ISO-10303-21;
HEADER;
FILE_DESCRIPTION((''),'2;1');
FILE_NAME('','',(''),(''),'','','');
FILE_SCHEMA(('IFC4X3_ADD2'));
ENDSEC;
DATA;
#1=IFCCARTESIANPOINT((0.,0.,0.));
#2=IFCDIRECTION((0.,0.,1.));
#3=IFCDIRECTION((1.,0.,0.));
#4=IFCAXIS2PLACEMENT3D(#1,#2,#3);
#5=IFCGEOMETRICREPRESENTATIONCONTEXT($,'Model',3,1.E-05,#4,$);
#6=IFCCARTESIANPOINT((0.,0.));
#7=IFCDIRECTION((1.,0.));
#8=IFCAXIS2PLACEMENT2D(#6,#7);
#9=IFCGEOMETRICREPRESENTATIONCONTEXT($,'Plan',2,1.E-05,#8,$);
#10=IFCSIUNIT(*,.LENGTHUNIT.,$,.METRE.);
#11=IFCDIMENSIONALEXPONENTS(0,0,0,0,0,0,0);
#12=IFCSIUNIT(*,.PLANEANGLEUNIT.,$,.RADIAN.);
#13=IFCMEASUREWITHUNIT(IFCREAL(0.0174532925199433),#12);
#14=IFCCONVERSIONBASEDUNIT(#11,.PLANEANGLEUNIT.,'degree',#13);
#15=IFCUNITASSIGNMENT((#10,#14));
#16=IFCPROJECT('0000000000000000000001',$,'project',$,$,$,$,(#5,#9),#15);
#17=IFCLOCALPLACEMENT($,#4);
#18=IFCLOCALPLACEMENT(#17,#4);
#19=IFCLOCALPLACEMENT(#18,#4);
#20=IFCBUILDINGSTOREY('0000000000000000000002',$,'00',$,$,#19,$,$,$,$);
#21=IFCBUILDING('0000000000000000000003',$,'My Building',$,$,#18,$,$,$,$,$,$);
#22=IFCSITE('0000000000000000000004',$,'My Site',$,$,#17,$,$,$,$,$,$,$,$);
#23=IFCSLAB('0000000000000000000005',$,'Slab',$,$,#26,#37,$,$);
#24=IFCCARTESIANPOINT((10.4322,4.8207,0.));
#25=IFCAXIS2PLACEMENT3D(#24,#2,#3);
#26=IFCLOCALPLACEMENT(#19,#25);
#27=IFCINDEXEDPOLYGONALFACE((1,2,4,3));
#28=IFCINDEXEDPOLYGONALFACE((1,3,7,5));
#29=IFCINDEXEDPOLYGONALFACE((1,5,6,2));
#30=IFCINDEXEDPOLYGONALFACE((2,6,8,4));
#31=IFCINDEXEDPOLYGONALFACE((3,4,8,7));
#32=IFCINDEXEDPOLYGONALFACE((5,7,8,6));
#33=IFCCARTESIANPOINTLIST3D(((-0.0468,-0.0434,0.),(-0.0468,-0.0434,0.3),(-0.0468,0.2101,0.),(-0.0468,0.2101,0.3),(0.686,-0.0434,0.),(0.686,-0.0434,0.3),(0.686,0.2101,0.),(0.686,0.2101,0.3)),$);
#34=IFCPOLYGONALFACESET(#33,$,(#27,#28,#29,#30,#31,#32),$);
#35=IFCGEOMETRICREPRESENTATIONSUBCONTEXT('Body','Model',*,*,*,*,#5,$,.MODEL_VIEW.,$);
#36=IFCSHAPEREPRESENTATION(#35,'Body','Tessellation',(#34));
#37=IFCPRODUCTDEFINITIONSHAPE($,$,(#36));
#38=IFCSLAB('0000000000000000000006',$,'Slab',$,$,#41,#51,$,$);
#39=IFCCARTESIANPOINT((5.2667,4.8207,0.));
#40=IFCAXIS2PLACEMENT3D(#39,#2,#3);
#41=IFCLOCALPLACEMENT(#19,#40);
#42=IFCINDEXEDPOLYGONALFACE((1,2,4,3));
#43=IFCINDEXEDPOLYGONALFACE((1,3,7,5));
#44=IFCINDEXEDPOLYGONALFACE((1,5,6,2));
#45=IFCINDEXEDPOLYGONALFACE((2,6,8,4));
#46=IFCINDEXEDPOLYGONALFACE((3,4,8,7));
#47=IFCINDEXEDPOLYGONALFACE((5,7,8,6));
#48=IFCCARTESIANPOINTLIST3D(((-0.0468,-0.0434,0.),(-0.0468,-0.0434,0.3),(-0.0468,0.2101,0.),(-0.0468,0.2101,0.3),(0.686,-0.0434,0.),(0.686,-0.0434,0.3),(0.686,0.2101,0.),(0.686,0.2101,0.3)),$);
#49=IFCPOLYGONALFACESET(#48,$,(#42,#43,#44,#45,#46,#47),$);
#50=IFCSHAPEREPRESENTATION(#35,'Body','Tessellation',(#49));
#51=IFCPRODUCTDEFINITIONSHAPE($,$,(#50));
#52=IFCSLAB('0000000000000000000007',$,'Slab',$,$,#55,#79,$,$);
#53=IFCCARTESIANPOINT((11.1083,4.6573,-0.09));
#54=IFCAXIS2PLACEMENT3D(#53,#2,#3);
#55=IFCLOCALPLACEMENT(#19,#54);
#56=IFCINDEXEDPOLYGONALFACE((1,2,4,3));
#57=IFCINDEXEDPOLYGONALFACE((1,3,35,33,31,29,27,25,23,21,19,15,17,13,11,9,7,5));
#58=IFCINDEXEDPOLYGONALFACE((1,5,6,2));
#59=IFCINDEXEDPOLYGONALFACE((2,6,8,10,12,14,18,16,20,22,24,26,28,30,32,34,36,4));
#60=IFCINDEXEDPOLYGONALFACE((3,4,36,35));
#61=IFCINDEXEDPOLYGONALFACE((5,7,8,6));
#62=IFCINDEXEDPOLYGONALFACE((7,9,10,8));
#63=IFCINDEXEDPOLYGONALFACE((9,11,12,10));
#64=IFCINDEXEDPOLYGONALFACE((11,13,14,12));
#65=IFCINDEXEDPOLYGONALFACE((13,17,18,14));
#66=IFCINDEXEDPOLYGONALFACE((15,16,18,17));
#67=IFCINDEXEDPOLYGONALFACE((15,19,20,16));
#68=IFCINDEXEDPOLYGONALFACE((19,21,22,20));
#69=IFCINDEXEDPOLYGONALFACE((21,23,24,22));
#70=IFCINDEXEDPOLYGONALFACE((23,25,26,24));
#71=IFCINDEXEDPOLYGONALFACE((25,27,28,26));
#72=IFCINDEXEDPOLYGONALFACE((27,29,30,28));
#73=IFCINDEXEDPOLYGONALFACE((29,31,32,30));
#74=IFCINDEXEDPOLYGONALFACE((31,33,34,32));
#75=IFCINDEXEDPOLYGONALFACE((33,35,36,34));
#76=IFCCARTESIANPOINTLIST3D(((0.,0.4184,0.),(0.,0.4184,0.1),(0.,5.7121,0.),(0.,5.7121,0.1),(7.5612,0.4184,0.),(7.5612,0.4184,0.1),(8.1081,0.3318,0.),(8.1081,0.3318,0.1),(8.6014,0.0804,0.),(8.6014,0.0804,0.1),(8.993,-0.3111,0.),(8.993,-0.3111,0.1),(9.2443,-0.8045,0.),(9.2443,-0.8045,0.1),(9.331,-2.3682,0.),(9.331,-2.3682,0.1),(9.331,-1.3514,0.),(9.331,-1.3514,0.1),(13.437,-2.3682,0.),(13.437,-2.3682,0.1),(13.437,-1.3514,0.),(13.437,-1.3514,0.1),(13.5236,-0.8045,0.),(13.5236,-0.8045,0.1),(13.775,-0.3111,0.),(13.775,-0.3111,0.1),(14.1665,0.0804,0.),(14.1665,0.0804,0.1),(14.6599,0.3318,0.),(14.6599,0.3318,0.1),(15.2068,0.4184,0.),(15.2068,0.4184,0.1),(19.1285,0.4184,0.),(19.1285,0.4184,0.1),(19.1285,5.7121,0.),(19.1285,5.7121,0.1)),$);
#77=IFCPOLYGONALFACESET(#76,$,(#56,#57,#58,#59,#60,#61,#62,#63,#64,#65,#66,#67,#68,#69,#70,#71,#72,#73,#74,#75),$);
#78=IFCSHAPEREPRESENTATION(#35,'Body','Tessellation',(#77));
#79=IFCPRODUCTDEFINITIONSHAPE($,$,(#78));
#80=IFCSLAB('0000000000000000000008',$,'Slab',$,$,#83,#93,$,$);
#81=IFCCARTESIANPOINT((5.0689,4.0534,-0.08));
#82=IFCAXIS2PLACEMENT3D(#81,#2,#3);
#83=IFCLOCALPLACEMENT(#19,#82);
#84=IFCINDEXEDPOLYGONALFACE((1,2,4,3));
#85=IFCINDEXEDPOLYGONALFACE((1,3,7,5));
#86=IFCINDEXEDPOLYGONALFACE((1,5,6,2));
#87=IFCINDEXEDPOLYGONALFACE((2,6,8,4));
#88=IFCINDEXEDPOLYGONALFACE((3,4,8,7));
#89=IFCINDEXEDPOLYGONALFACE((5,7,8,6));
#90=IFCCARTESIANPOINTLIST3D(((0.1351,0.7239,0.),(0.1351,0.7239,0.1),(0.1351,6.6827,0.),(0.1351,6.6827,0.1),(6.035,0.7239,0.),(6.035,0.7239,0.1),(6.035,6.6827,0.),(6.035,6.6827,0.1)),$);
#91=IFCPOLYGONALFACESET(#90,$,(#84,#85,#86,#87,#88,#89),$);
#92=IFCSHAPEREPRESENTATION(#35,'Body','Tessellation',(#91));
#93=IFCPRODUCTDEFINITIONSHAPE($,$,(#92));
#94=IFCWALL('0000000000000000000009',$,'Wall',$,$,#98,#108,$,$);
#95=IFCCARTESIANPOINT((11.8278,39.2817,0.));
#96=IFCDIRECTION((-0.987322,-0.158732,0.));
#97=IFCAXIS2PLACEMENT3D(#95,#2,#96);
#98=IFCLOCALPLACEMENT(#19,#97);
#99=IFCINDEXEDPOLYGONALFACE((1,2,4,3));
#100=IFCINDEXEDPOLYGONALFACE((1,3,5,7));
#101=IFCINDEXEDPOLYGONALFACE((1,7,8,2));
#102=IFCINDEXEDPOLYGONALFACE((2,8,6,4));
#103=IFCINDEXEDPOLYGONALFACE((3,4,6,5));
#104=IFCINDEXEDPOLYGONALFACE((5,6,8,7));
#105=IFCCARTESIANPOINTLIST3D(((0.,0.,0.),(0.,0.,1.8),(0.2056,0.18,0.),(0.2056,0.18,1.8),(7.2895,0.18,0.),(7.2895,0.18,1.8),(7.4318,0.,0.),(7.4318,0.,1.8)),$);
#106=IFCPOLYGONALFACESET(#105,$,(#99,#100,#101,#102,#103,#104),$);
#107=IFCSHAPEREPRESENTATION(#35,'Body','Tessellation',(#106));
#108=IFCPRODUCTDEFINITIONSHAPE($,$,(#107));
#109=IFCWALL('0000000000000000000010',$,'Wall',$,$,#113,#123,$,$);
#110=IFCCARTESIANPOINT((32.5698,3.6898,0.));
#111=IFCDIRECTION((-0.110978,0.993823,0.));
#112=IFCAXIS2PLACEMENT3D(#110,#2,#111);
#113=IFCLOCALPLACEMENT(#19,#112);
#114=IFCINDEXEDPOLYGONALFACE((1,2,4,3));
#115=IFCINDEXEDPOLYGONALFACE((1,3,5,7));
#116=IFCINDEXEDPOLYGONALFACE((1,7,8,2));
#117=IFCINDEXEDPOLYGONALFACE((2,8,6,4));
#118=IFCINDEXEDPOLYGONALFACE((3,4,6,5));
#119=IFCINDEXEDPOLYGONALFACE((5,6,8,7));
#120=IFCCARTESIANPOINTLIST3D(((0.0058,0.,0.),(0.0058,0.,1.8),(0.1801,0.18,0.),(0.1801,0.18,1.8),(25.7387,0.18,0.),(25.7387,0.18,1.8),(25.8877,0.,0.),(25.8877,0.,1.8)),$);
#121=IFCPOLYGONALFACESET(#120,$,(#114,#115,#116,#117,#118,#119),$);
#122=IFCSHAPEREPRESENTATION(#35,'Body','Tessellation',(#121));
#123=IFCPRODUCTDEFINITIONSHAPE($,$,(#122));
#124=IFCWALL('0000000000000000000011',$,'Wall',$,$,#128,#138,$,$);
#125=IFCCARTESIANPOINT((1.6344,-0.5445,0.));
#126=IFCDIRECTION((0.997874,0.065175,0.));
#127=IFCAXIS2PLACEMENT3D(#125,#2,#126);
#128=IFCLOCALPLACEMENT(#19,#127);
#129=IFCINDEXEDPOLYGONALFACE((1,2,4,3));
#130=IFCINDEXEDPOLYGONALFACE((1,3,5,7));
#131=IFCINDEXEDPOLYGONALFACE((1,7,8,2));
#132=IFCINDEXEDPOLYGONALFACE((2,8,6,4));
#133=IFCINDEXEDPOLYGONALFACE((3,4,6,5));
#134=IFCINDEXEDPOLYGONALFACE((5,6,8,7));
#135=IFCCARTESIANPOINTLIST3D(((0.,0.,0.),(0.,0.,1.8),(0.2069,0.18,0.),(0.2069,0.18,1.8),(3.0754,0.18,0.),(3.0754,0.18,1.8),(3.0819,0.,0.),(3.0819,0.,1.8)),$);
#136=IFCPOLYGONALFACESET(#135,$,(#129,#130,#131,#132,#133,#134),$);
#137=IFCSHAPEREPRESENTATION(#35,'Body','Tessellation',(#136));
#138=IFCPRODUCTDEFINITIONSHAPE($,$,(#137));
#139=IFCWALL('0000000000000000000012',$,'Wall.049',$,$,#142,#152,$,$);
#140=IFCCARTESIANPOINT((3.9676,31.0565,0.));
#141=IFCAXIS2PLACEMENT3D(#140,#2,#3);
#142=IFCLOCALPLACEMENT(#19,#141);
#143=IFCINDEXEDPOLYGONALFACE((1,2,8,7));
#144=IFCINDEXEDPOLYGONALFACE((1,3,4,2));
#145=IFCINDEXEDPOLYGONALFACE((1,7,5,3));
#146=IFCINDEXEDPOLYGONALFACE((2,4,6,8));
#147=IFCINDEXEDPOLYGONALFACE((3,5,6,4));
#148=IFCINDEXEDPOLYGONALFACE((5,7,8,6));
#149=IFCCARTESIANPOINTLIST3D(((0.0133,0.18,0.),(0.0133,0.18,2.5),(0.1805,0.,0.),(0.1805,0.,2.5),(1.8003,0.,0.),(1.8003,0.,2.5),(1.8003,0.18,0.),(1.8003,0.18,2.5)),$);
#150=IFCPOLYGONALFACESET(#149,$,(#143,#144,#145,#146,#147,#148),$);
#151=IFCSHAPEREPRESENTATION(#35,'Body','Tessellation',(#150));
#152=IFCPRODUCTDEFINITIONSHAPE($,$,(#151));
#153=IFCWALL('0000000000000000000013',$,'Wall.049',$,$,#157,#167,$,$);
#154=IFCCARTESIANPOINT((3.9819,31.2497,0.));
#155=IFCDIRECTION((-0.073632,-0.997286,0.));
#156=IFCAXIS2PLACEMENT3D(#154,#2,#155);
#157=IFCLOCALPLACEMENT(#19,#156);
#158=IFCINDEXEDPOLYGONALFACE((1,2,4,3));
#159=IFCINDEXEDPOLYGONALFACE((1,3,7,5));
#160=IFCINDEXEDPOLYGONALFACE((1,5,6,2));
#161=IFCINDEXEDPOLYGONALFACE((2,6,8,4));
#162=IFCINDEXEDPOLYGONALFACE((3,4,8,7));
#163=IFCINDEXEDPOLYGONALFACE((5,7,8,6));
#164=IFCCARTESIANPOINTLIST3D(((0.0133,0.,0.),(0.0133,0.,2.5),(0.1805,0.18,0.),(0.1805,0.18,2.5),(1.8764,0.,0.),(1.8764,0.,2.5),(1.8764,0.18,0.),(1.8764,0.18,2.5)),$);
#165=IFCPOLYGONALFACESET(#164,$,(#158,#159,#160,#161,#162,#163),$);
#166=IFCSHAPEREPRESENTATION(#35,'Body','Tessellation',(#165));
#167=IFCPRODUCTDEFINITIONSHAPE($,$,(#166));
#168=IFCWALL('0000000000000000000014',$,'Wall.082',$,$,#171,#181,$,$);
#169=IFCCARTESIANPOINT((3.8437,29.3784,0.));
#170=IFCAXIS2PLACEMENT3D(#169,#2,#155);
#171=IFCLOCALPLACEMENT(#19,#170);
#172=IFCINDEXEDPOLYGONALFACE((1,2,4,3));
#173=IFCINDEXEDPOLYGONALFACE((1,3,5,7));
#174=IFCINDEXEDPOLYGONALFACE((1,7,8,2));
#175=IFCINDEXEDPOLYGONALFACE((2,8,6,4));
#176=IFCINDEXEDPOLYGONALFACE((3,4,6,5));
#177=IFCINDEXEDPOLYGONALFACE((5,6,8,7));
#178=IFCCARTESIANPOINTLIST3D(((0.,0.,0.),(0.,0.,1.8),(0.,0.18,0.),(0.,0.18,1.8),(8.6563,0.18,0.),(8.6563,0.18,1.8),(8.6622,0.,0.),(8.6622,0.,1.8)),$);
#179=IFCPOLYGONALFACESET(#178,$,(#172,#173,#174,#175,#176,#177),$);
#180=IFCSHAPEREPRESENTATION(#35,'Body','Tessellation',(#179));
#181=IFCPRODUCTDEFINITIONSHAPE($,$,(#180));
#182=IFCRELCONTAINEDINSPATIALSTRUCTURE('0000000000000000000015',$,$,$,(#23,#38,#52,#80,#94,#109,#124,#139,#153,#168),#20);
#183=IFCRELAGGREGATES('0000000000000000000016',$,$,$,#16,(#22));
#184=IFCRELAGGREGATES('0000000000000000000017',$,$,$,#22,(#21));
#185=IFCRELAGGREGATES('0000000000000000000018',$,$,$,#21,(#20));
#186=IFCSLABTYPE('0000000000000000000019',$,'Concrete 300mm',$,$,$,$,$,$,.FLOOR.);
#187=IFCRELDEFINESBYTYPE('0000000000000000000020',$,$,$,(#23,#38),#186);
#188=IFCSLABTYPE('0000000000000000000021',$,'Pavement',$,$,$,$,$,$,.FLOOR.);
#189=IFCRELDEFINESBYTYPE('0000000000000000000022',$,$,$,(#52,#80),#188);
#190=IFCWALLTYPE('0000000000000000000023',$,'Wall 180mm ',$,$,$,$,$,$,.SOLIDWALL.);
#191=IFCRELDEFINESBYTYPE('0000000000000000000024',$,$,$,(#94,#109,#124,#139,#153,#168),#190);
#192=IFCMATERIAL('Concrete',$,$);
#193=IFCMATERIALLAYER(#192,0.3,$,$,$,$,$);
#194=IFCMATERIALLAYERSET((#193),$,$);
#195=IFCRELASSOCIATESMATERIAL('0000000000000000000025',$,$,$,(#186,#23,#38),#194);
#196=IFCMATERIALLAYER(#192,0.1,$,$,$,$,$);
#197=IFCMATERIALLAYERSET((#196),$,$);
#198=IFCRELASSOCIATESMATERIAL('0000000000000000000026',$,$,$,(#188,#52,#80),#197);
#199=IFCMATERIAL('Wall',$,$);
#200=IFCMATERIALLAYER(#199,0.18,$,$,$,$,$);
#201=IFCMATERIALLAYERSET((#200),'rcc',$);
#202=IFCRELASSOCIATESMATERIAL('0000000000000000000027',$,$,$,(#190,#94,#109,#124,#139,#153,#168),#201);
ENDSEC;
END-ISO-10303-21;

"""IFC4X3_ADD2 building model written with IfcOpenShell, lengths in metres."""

from ifc_helpers import new_model, entity, si_unit, converted_unit, frame, origin_with_axes, origin_2d_with_axis, place, context, subcontext, project, spatial, line, indexed_curve, outline, extrude, clip, halfspace, material, layer, layer_set, layer_usage, type_object, element, save


model = new_model("IFC4X3_ADD2")

# Units and contexts
model_context = context("Model", 3, precision=1e-05, world=origin_with_axes())
plan_context = context("Plan", 2, precision=1e-05, world=origin_2d_with_axis())
body_context_1 = subcontext(model_context, "Body", "Model", "MODEL_VIEW")
ifc_project = project(units=[si_unit("LENGTHUNIT", "METRE"), converted_unit("PLANEANGLEUNIT", "degree", entity("IfcReal", 0.0174532925199433), si_unit("PLANEANGLEUNIT", "RADIAN"), dimensions=[0, 0, 0, 0, 0, 0, 0])], contexts=[model_context, plan_context])

# Site, building, storey
site_placement = place(None, origin_with_axes())
site = spatial("IfcSite", under=ifc_project, at=site_placement, Name="My Site")
building_placement = place(site_placement, origin_with_axes())
building = spatial("IfcBuilding", under=site, at=building_placement, Name="My Building")
storey_placement = place(building_placement, origin_with_axes())
storey = spatial("IfcBuildingStorey", under=building, at=storey_placement, Name="00")

# Slabs
ifc_material_1 = material(Name="Concrete")
ifc_layer_1 = layer(ifc_material_1, 0.3)
ifc_layer_set_1 = layer_set([ifc_layer_1])
ifc_layer_usage_1 = layer_usage(ifc_layer_set_1, "AXIS3", "POSITIVE", 0.0)
slab_type_1 = type_object("IfcSlabType", Name="Concrete 300mm", PredefinedType="FLOOR", material=ifc_layer_set_1)
slab_1_placement = place(storey_placement, frame((10.4322, 4.8207, 0.0), z_axis=(0.0, 0.0, 1.0), x_axis=(1.0, 0.0, 0.0)))
element("IfcSlab", 1, at=slab_1_placement, inside=storey, type_object=slab_type_1, material=ifc_layer_usage_1, Name="Slab", context=body_context_1, shape_type="SweptSolid", body=[
    extrude(outline(indexed_curve([(-0.0468, -0.0434), (0.686, -0.0434), (0.686, 0.2101), (-0.0468, 0.2101)], segments=[line(4, 1), line(1, 2), line(2, 3), line(3, 4)], self_intersect=False)), None, (0.0, 0.0, 1.0), 0.3),
])
ifc_layer_usage_2 = layer_usage(ifc_layer_set_1, "AXIS3", "POSITIVE", 0.0)
slab_2_placement = place(storey_placement, frame((5.2667, 4.8207, 0.0), z_axis=(0.0, 0.0, 1.0), x_axis=(1.0, 0.0, 0.0)))
element("IfcSlab", 2, at=slab_2_placement, inside=storey, type_object=slab_type_1, material=ifc_layer_usage_2, Name="Slab", context=body_context_1, shape_type="SweptSolid", body=[
    extrude(outline(indexed_curve([(-0.0468, 0.2101), (-0.0468, -0.0434), (0.686, -0.0434), (0.686, 0.2101)], segments=[line(4, 1), line(1, 2), line(2, 3), line(3, 4)], self_intersect=False)), None, (0.0, 0.0, 1.0), 0.3),
])
ifc_layer_2 = layer(ifc_material_1, 0.1)
ifc_layer_set_2 = layer_set([ifc_layer_2])
ifc_layer_usage_3 = layer_usage(ifc_layer_set_2, "AXIS3", "POSITIVE", 0.0)
slab_type_2 = type_object("IfcSlabType", Name="Pavement", PredefinedType="FLOOR", material=ifc_layer_set_2)
slab_3_placement = place(storey_placement, frame((11.1083, 4.6573, -0.09), z_axis=(0.0, 0.0, 1.0), x_axis=(1.0, 0.0, 0.0)))
element("IfcSlab", 3, at=slab_3_placement, inside=storey, type_object=slab_type_2, material=ifc_layer_usage_3, Name="Slab", context=body_context_1, shape_type="SweptSolid", body=[
    extrude(outline(indexed_curve([(8.1081, 0.3318), (7.5612, 0.4184), (0.0, 0.4184), (0.0, 5.7121), (19.1285, 5.7121), (19.1285, 0.4184), (15.2068, 0.4184), (14.6599, 0.3318), (14.1665, 0.0804), (13.775, -0.3111), (13.5236, -0.8045), (13.437, -1.3514), (13.437, -2.3682), (9.331, -2.3682), (9.331, -1.3514), (9.2443, -0.8045), (8.993, -0.3111), (8.6014, 0.0804)], segments=[line(3, 2), line(2, 1), line(1, 18), line(18, 17), line(17, 16), line(16, 15), line(15, 14), line(14, 13), line(13, 12), line(12, 11), line(11, 10), line(10, 9), line(9, 8), line(8, 7), line(7, 6), line(6, 5), line(5, 4), line(4, 3)], self_intersect=False)), None, (0.0, 0.0, 1.0), 0.1),
])
ifc_layer_usage_4 = layer_usage(ifc_layer_set_2, "AXIS3", "POSITIVE", 0.0)
slab_4_placement = place(storey_placement, frame((5.0689, 4.0534, -0.08), z_axis=(0.0, 0.0, 1.0), x_axis=(1.0, 0.0, 0.0)))
element("IfcSlab", 4, at=slab_4_placement, inside=storey, type_object=slab_type_2, material=ifc_layer_usage_4, Name="Slab", context=body_context_1, shape_type="SweptSolid", body=[
    extrude(outline(indexed_curve([(6.035, 0.7239), (0.1351, 0.7239), (0.1351, 6.6827), (6.035, 6.6827)], segments=[line(4, 1), line(1, 2), line(2, 3), line(3, 4)], self_intersect=False)), None, (0.0, 0.0, 1.0), 0.1),
])

# Walls
ifc_material_2 = material(Name="Wall")
ifc_layer_3 = layer(ifc_material_2, 0.18)
ifc_layer_set_3 = layer_set([ifc_layer_3], Name="rcc")
wall_type_1 = type_object("IfcWallType", Name="Wall 180mm ", PredefinedType="SOLIDWALL", material=ifc_layer_set_3)
ifc_layer_usage_5 = layer_usage(ifc_layer_set_3, "AXIS2", "POSITIVE", 0.0)
wall_1_placement = place(storey_placement, frame((11.8278, 39.2817, 0.0), z_axis=(0.0, 0.0, 1.0), x_axis=(-0.987322, -0.158732, 0.0)))
element("IfcWall", 5, at=wall_1_placement, inside=storey, type_object=wall_type_1, material=ifc_layer_usage_5, Name="Wall", context=body_context_1, shape_type="Clipping", body=[
    clip(clip(extrude(outline(indexed_curve([(0.0, 0.0), (0.0, 0.18), (7.4745, 0.18), (7.4745, 0.0), (0.0, 0.0)], self_intersect=False)), origin_with_axes(), (0.0, 0.0, 1.0), 1.8), halfspace(frame((7.4318, 0.0, 0.0), z_axis=(0.784559, 0.620055, 0.0), x_axis=(0.620055, -0.784558, 0.0)), False)), halfspace(frame((0.0, 0.0, 0.0), z_axis=(-0.658655, 0.752445, 0.0), x_axis=(0.752445, 0.658655, 0.0)), False)),
])
ifc_layer_usage_6 = layer_usage(ifc_layer_set_3, "AXIS2", "POSITIVE", 0.0)
wall_2_placement = place(storey_placement, frame((32.5698, 3.6898, 0.0), z_axis=(0.0, 0.0, 1.0), x_axis=(-0.110978, 0.993823, 0.0)))
element("IfcWall", 6, at=wall_2_placement, inside=storey, type_object=wall_type_1, material=ifc_layer_usage_6, Name="Wall", context=body_context_1, shape_type="Clipping", body=[
    clip(clip(extrude(outline(indexed_curve([(0.0, 0.0), (0.0, 0.18), (25.9219, 0.18), (25.9219, 0.0), (0.0, 0.0)], self_intersect=False)), origin_with_axes(), (0.0, 0.0, 1.0), 1.8), halfspace(frame((0.0058, 0.0, 0.0), z_axis=(-0.718417, 0.695612, 0.0), x_axis=(0.695612, 0.718418, 0.0)), False)), halfspace(frame((25.8877, 0.0, 0.0), z_axis=(0.770377, 0.637589, 0.0), x_axis=(0.637589, -0.770377, 0.0)), False)),
])
ifc_layer_usage_7 = layer_usage(ifc_layer_set_3, "AXIS2", "POSITIVE", 0.0)
wall_3_placement = place(storey_placement, frame((1.6344, -0.5445, 0.0), z_axis=(0.0, 0.0, 1.0), x_axis=(0.997874, 0.065175, 0.0)))
element("IfcWall", 7, at=wall_3_placement, inside=storey, type_object=wall_type_1, material=ifc_layer_usage_7, Name="Wall", context=body_context_1, shape_type="Clipping", body=[
    clip(clip(extrude(outline(indexed_curve([(0.0, 0.0), (0.0, 0.18), (5.5676, 0.18), (5.5676, 0.0), (0.0, 0.0)], self_intersect=False)), origin_with_axes(), (0.0, 0.0, 1.0), 1.8), halfspace(frame((3.0819, 0.0, 0.0), z_axis=(0.999347, 0.036143, 0.0), x_axis=(0.036143, -0.999347, 0.0)), False)), halfspace(frame((0.0, 0.0, 0.0), z_axis=(-0.656326, 0.754478, 0.0), x_axis=(0.754478, 0.656326, 0.0)), False)),
])
ifc_layer_usage_8 = layer_usage(ifc_layer_set_3, "AXIS2", "POSITIVE", 0.0)
wall_4_placement = place(storey_placement, frame((3.9676, 31.0565, 0.0), z_axis=(0.0, 0.0, 1.0), x_axis=(1.0, 0.0, 0.0)))
element("IfcWall", 8, at=wall_4_placement, inside=storey, type_object=wall_type_1, material=ifc_layer_usage_8, Name="Wall.049", context=body_context_1, shape_type="Clipping", body=[
    clip(extrude(outline(indexed_curve([(0.0, 0.0), (0.0, 0.18), (1.8003, 0.18), (1.8003, 0.0), (0.0, 0.0)], self_intersect=False)), origin_with_axes(), (0.0, 0.0, 1.0), 2.5), halfspace(frame((0.1805, 0.0, 0.0), z_axis=(-0.732678, -0.680576, 0.0), x_axis=(-0.680576, 0.732678, 0.0)), False)),
])

# Wall
ifc_layer_usage_9 = layer_usage(ifc_layer_set_3, "AXIS2", "POSITIVE", 0.0)
wall_5_placement = place(storey_placement, frame((3.9819, 31.2497, 0.0), z_axis=(0.0, 0.0, 1.0), x_axis=(-0.073632, -0.997286, 0.0)))
element("IfcWall", 9, at=wall_5_placement, inside=storey, type_object=wall_type_1, material=ifc_layer_usage_9, Name="Wall.049", context=body_context_1, shape_type="Clipping", body=[
    clip(extrude(outline(indexed_curve([(0.0, 0.0), (0.0, 0.18), (1.8764, 0.18), (1.8764, 0.0), (0.0, 0.0)], self_intersect=False)), origin_with_axes(), (0.0, 0.0, 1.0), 2.5), halfspace(frame((0.0133, 0.0, 0.0), z_axis=(-0.732676, 0.680577, 0.0), x_axis=(0.680577, 0.732676, 0.0)), False)),
])

# Wall
ifc_layer_usage_10 = layer_usage(ifc_layer_set_3, "AXIS2", "POSITIVE", 0.0)
wall_6_placement = place(storey_placement, frame((3.8437, 29.3784, 0.0), z_axis=(0.0, 0.0, 1.0), x_axis=(-0.073632, -0.997286, 0.0)))
element("IfcWall", 10, at=wall_6_placement, inside=storey, type_object=wall_type_1, material=ifc_layer_usage_10, Name="Wall.082", context=body_context_1, shape_type="Clipping", body=[
    clip(extrude(outline(indexed_curve([(0.0, 0.0), (0.0, 0.18), (11.4097, 0.18), (11.4097, 0.0), (0.0, 0.0)], self_intersect=False)), origin_with_axes(), (0.0, 0.0, 1.0), 1.8), halfspace(frame((8.6622, 0.0, 0.0), z_axis=(0.999467, 0.032653, 0.0), x_axis=(0.032653, -0.999467, 0.0)), False)),
])

save(model, "model.ifc")
